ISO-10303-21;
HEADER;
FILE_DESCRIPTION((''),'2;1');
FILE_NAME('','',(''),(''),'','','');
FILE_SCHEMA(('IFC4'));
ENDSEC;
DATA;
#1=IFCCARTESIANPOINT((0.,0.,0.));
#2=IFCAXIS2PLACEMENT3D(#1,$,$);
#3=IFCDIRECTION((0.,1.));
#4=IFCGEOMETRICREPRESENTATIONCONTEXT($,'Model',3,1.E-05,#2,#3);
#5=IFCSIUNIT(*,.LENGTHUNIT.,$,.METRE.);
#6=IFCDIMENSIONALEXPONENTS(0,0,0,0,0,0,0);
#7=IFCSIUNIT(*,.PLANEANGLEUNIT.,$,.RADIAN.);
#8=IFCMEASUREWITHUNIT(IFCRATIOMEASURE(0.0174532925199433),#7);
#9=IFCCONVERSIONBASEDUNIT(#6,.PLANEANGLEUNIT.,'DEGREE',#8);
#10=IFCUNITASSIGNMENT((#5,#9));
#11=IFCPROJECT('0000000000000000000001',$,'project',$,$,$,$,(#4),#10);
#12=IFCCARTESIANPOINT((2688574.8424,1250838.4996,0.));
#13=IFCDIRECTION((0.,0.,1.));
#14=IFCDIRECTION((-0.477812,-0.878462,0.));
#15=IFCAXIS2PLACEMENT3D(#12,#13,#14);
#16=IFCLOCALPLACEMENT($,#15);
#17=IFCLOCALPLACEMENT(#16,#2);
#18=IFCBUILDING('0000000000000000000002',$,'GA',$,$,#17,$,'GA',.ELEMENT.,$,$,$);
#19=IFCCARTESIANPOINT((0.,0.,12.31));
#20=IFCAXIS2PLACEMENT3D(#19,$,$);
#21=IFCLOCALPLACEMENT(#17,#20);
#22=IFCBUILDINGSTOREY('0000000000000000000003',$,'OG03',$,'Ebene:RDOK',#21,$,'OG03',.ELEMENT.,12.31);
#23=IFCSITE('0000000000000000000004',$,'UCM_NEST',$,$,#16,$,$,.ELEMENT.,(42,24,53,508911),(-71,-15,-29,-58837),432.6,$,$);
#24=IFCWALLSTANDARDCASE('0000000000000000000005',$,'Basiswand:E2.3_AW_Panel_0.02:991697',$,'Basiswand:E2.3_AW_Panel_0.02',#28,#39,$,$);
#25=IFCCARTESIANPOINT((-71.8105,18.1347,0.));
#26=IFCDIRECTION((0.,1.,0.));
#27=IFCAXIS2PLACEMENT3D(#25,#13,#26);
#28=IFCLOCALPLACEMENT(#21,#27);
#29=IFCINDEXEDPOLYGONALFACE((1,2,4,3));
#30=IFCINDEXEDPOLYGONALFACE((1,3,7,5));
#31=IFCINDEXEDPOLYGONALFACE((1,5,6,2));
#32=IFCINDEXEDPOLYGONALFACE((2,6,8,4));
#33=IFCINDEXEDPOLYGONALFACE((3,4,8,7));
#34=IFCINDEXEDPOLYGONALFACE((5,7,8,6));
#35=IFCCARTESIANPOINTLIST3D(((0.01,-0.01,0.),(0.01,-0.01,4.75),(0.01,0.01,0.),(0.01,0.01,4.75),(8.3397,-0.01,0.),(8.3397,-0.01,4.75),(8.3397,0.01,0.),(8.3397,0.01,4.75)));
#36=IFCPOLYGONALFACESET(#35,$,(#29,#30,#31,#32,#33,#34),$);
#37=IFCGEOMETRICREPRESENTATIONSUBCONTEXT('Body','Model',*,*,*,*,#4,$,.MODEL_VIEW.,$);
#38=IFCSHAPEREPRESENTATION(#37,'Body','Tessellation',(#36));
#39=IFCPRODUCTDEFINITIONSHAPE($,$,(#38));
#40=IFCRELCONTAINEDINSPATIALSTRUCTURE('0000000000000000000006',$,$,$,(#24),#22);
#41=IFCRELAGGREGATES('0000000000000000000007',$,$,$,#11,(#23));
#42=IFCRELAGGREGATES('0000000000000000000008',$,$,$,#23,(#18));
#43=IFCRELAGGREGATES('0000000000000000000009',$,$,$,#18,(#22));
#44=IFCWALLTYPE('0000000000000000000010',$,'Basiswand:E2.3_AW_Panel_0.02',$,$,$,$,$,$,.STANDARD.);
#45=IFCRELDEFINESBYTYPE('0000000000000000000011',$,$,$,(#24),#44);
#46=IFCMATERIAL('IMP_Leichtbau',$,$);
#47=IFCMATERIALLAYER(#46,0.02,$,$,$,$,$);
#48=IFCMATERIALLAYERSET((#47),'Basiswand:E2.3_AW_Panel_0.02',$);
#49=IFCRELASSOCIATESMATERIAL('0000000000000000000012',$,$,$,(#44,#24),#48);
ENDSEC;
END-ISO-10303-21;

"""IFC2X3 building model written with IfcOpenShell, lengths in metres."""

from ifc_helpers import new_model, entity, si_unit, converted_unit, direction, frame, frame_2d, origin, place, context, subcontext, project, spatial, rectangle, extrude, material, layer, layer_set, layer_usage, type_object, element, save


model = new_model("IFC2X3")

# Units and contexts
model_context = context("Model", 3, precision=1e-05, world=origin(), true_north=direction((0.0, 1.0)))
body_context = subcontext(model_context, "Body", "Model", "MODEL_VIEW")
ifc_project = project(units=[si_unit("LENGTHUNIT", "METRE"), converted_unit("PLANEANGLEUNIT", "DEGREE", entity("IfcRatioMeasure", 0.0174532925199433), si_unit("PLANEANGLEUNIT", "RADIAN"), dimensions=[0, 0, 0, 0, 0, 0, 0])], contexts=[model_context])

# Site, building, storey
site_placement = place(None, frame((2688574.8424, 1250838.4996, 0.0), z_axis=(0.0, 0.0, 1.0), x_axis=(-0.477812, -0.878462, 0.0)))
site = spatial("IfcSite", under=ifc_project, at=site_placement, Name="UCM_NEST", CompositionType="ELEMENT", RefLatitude=(42, 24, 53, 508911), RefLongitude=(-71, -15, -29, -58837), RefElevation=432.6)
building_placement = place(site_placement, origin())
building = spatial("IfcBuilding", under=site, at=building_placement, Name="GA", LongName="GA", CompositionType="ELEMENT")
storey_placement = place(building_placement, frame((0.0, 0.0, 12.31)))
storey = spatial("IfcBuildingStorey", under=building, at=storey_placement, Name="OG03", ObjectType="Ebene:RDOK", LongName="OG03", CompositionType="ELEMENT", Elevation=12.31)

# Shared definitions
ifc_material_1 = material(Name="IMP_Leichtbau")

# Wall
ifc_layer_1 = layer(ifc_material_1, 0.02)
ifc_layer_set_1 = layer_set([ifc_layer_1], Name="Basiswand:E2.3_AW_Panel_0.02")
wall_type_1 = type_object("IfcWallType", Name="Basiswand:E2.3_AW_Panel_0.02", PredefinedType="STANDARD", material=ifc_layer_set_1)
ifc_layer_usage_1 = layer_usage(ifc_layer_set_1, "AXIS2", "NEGATIVE", 0.01)
wall_1_placement = place(storey_placement, frame((-71.8105, 18.1347, 0.0), z_axis=(0.0, 0.0, 1.0), x_axis=(0.0, 1.0, 0.0)))
element("IfcWallStandardCase", 1, at=wall_1_placement, inside=storey, type_object=wall_type_1, material=ifc_layer_usage_1, Name="Basiswand:E2.3_AW_Panel_0.02:991697", ObjectType="Basiswand:E2.3_AW_Panel_0.02", context=body_context, shape_type="SweptSolid", body=[
    extrude(rectangle(XDim=8.3297, YDim=0.02, at=frame_2d((4.1749, 0.0), x_axis=(-1.0, 0.0))), origin(), (0.0, 0.0, 1.0), 4.75),
])

save(model, "model.ifc")
